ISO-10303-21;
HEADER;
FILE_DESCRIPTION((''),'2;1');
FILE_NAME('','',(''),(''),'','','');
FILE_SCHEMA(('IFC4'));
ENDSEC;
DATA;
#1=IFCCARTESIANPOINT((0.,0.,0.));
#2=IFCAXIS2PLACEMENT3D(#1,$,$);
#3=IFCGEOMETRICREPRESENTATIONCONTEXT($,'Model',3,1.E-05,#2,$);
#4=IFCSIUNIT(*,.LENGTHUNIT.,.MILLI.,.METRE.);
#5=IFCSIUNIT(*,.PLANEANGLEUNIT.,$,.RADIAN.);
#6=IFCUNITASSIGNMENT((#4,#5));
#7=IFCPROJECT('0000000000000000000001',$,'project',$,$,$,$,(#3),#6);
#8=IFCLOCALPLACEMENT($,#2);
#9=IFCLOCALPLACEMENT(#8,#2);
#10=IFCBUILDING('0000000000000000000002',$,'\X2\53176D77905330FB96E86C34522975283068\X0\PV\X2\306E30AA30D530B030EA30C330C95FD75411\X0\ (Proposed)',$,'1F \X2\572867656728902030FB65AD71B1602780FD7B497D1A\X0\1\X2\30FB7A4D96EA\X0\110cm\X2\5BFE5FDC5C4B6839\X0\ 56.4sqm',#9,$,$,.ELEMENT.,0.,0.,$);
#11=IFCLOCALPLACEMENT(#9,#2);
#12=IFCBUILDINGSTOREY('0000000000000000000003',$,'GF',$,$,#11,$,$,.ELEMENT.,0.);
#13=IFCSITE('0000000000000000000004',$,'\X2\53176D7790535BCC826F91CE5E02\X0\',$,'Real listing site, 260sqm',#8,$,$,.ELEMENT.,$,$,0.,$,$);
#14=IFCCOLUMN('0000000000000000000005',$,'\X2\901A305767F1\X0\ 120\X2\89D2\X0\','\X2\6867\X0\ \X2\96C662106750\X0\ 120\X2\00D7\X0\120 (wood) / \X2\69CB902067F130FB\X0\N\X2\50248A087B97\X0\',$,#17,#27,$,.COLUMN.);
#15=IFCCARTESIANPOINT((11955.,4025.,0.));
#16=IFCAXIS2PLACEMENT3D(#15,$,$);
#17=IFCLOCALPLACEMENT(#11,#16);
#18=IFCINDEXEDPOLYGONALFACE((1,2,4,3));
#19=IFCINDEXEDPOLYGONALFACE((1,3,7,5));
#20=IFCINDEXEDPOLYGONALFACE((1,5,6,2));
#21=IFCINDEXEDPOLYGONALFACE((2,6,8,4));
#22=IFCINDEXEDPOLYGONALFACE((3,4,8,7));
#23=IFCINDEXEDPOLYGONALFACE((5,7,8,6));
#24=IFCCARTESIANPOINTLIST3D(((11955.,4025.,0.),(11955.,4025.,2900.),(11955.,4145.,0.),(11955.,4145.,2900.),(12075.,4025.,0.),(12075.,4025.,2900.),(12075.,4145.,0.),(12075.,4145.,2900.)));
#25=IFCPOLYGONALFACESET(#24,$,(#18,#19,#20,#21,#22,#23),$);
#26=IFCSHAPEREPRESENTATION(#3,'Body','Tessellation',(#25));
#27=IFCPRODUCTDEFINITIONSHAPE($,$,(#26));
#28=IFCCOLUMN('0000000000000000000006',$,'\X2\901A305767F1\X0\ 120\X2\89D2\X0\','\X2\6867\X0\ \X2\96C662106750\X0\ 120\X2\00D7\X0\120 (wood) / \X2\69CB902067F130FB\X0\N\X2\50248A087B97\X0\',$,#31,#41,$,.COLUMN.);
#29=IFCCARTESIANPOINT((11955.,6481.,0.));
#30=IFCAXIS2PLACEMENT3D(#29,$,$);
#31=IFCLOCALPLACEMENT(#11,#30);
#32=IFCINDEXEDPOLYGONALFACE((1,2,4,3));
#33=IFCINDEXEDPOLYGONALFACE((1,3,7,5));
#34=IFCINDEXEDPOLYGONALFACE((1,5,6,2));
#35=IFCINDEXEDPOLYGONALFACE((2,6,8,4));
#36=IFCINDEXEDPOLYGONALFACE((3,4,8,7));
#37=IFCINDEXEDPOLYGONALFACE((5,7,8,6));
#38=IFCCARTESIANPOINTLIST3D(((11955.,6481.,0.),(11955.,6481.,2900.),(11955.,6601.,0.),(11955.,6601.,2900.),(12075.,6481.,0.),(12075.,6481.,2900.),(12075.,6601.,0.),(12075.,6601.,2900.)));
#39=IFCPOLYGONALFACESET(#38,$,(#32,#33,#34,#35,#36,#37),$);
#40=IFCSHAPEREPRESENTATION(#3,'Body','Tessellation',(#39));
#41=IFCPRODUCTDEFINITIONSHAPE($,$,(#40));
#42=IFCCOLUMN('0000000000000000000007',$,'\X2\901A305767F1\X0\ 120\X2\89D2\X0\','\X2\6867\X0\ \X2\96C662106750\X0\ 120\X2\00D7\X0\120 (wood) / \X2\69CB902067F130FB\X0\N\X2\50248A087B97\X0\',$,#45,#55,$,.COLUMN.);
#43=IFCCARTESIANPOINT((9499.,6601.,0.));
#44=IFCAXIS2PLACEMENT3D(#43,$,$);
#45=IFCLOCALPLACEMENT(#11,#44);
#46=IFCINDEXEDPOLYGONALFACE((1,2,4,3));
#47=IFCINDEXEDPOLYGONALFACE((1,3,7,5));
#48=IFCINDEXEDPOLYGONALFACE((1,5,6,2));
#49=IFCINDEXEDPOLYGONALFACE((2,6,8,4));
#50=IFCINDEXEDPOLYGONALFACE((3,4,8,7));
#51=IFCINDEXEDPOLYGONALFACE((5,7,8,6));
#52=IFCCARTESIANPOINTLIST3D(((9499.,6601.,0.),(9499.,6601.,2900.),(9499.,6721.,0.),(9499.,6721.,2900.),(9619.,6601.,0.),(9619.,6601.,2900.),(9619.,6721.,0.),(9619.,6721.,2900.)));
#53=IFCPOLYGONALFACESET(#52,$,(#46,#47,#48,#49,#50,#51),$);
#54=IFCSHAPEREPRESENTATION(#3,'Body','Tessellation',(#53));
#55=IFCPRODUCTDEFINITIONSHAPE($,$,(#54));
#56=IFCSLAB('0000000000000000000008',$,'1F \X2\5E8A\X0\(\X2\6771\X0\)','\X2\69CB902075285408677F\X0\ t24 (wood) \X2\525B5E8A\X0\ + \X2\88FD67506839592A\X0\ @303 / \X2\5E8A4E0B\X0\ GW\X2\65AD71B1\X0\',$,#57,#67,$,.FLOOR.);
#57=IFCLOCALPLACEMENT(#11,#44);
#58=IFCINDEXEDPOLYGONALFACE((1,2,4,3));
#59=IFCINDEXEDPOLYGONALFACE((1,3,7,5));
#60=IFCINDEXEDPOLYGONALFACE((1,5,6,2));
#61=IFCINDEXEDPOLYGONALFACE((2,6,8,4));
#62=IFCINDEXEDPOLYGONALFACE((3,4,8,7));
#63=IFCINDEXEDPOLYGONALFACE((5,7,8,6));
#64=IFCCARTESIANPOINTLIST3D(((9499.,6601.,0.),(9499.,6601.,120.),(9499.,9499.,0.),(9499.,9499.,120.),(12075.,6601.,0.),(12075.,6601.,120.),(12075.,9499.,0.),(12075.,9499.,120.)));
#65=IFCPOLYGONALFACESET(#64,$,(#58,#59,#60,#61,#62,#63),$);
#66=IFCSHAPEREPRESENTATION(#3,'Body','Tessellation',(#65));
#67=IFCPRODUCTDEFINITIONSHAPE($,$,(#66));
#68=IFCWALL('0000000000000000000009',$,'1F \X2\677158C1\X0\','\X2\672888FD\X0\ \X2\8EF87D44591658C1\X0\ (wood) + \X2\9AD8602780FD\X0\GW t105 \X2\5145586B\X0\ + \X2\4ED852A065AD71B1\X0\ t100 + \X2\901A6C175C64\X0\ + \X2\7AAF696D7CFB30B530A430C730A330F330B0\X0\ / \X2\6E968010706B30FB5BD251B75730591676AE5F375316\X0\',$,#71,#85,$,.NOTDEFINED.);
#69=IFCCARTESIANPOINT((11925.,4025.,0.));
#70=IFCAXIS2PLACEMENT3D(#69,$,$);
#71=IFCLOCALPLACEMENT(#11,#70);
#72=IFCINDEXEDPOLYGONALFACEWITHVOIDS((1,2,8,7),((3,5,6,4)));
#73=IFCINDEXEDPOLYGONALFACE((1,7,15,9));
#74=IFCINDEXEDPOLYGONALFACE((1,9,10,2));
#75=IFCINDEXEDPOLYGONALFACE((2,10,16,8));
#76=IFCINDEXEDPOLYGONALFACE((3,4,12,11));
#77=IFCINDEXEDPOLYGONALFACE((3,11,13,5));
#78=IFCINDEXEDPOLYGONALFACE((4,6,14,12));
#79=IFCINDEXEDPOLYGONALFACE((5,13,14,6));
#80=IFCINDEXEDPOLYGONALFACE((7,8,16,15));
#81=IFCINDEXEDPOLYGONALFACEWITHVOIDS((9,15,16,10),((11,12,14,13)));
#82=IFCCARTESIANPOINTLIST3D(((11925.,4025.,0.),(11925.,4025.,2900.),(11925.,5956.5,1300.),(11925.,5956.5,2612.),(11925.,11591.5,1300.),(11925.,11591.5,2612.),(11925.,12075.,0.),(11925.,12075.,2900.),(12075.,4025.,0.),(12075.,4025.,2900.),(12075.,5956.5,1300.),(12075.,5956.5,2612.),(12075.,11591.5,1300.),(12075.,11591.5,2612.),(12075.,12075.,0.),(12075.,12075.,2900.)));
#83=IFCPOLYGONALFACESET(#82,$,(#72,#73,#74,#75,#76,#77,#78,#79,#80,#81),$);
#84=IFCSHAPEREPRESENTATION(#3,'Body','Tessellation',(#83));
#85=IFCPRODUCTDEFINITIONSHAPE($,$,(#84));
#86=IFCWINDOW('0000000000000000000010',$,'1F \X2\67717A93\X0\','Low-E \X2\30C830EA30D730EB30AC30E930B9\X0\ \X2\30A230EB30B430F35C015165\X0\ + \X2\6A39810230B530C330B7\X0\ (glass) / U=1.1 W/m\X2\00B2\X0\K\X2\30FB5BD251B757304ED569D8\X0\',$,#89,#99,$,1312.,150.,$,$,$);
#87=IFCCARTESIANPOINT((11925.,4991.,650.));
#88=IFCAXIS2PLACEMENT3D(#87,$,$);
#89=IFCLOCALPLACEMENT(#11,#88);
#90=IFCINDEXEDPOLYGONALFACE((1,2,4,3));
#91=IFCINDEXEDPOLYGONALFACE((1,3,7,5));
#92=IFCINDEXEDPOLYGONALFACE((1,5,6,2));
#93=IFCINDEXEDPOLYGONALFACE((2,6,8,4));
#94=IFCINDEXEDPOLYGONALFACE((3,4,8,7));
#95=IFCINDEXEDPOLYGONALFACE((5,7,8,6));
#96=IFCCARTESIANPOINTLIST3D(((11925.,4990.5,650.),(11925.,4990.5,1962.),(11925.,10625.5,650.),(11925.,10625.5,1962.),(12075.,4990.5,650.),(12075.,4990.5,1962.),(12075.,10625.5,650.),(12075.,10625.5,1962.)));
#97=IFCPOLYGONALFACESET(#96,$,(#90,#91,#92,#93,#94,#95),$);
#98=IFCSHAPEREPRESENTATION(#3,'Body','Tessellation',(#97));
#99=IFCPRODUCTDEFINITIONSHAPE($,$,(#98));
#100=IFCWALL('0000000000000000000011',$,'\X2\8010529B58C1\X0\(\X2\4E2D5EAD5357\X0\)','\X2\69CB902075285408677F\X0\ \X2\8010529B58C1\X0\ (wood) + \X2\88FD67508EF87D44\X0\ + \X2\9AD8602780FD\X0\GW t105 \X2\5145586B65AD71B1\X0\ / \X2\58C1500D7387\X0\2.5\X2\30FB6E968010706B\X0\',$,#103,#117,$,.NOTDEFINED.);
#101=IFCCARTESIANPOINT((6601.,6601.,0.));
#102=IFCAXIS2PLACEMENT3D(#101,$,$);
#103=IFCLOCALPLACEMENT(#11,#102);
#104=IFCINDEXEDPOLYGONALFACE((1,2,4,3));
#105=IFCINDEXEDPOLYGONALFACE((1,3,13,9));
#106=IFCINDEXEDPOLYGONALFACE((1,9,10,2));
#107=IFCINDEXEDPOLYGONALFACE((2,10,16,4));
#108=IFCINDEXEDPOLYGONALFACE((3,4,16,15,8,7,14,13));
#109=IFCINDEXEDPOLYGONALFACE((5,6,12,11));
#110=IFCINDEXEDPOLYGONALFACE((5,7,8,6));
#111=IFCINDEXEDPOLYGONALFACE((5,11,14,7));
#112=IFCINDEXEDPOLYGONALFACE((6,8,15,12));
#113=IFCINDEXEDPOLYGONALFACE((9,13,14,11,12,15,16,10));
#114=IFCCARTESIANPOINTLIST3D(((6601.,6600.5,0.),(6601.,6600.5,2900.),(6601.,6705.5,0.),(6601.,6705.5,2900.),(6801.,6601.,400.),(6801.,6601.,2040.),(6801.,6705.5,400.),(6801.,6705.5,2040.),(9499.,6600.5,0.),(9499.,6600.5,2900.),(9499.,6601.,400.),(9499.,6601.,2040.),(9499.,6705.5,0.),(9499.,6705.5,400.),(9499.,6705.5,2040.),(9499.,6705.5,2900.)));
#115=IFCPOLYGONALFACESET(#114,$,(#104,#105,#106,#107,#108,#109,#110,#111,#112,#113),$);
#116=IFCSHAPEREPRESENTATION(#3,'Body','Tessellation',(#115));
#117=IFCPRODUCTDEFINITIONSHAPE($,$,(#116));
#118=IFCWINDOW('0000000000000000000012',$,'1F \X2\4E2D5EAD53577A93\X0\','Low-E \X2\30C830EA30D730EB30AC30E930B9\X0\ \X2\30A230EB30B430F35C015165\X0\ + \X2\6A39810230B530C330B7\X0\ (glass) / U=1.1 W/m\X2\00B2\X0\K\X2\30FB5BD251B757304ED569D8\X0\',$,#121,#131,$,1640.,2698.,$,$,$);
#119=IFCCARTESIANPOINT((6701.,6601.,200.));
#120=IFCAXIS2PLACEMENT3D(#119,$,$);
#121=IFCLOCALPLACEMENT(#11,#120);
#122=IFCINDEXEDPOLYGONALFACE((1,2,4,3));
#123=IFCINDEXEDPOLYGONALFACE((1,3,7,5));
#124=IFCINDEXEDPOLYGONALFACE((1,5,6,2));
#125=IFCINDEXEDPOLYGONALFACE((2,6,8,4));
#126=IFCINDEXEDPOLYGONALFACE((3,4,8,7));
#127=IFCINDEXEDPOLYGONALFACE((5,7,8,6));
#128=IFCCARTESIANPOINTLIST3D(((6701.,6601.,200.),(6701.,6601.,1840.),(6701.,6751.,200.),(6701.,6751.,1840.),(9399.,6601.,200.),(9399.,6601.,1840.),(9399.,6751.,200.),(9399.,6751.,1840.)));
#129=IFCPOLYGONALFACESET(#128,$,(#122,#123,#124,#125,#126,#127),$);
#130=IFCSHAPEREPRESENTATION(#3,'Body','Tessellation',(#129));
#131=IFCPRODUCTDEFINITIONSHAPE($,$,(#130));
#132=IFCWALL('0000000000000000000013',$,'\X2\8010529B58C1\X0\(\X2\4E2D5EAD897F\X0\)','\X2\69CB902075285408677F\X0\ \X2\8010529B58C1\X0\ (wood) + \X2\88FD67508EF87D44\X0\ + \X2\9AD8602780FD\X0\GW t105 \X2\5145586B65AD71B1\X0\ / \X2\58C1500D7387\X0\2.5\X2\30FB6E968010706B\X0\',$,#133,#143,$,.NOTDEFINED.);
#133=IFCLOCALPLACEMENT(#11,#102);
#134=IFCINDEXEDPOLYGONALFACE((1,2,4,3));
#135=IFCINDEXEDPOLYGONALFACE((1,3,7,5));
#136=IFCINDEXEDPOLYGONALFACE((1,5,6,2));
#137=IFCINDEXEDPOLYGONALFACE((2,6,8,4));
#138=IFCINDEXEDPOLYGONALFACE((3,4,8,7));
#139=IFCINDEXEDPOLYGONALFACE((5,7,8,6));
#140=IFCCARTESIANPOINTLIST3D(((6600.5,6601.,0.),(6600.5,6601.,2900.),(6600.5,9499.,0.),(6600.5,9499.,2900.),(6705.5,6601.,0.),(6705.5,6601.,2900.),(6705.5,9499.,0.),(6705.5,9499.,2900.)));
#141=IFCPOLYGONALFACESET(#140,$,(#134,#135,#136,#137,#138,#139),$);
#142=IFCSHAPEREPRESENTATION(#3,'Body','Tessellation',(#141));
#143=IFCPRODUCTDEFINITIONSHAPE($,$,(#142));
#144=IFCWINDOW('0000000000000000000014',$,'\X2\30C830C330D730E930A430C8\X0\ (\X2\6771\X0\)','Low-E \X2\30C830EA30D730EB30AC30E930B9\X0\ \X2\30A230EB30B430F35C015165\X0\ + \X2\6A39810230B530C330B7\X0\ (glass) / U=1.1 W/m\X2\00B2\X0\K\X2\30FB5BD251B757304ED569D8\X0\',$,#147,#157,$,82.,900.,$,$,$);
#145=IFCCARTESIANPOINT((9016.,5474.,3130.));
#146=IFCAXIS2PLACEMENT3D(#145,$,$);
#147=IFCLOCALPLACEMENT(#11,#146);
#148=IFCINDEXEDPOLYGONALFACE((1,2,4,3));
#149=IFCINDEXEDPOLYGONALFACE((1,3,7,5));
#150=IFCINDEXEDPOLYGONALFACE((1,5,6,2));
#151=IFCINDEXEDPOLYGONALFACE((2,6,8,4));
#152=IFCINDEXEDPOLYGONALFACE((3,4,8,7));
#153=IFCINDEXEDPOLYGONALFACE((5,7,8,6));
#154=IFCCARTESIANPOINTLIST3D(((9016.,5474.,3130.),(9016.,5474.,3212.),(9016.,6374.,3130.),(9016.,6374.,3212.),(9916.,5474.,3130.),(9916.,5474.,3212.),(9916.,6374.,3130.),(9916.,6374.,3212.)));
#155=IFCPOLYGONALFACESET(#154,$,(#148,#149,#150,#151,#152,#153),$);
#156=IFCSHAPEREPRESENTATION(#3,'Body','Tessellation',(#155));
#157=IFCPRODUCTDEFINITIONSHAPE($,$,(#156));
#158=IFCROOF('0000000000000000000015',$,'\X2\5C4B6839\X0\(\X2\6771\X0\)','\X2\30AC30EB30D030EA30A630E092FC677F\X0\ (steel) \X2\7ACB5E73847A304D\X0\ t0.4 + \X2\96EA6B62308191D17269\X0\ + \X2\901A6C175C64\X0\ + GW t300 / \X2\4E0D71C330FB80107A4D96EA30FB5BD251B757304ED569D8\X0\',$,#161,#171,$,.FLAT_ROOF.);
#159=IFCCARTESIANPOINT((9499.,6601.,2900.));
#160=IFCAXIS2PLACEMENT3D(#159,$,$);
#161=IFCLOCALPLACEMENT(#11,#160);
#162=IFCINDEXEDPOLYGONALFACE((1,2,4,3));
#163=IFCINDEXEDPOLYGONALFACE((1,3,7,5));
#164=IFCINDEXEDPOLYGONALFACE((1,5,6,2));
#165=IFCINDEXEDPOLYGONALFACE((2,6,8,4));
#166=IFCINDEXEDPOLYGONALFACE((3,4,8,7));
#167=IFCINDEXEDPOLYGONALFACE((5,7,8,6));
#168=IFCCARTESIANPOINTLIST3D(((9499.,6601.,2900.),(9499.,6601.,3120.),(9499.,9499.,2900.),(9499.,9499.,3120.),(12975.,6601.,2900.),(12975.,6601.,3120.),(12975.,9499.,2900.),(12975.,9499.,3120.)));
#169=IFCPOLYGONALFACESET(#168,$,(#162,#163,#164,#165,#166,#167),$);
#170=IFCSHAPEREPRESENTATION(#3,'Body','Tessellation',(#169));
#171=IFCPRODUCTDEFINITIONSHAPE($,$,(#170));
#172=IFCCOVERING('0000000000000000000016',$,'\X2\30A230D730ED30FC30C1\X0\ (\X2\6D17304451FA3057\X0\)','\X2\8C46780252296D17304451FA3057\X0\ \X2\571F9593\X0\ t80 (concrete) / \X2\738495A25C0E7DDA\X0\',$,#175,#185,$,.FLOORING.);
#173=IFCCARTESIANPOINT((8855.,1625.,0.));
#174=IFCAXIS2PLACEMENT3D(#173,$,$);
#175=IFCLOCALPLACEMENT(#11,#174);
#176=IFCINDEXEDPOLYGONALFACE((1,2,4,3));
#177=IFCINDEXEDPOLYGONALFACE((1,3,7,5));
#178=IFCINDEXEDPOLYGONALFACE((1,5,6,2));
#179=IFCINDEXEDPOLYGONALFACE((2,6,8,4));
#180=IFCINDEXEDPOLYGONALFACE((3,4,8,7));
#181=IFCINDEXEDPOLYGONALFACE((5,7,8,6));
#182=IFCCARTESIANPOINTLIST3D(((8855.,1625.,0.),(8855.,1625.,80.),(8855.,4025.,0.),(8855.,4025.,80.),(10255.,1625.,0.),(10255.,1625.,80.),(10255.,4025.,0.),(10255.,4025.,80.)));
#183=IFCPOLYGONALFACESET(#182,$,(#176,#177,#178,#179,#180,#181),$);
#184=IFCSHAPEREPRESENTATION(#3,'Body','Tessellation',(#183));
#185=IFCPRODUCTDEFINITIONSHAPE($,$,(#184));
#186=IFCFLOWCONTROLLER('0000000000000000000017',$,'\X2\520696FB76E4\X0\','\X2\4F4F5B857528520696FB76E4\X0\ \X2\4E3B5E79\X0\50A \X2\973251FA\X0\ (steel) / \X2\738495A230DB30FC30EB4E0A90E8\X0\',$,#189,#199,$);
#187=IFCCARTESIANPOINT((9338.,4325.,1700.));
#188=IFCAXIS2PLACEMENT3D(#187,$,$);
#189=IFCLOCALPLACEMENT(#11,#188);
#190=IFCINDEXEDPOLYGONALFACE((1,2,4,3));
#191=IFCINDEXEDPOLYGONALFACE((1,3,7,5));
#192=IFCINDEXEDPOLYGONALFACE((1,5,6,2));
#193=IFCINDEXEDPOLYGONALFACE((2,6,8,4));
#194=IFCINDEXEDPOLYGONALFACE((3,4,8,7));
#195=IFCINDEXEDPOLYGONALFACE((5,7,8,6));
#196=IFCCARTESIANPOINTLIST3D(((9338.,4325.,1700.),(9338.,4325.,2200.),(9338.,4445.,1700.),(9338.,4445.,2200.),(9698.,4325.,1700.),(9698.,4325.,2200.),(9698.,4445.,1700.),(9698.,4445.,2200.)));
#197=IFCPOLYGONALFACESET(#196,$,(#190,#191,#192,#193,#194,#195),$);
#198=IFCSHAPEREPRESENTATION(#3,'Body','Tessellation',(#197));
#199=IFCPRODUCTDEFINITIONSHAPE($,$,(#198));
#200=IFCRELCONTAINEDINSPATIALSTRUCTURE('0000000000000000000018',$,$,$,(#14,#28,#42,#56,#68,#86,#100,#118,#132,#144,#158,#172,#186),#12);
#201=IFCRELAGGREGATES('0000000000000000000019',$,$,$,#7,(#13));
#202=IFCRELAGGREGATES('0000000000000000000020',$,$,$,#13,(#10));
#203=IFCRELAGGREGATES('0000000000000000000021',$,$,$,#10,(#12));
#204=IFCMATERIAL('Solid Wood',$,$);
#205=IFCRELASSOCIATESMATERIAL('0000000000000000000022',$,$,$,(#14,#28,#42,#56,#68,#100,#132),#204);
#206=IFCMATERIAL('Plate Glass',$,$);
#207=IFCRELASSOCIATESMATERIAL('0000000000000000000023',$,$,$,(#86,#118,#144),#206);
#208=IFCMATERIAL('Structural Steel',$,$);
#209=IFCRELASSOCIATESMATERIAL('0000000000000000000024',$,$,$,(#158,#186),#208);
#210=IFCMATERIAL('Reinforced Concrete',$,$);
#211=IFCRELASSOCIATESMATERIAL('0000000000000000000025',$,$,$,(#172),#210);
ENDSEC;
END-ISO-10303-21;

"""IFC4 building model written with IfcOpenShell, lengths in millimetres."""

from ifc_helpers import new_model, si_unit, frame, frame_2d, origin, place, context, project, spatial, rectangle, extrude, material, element, fill, save


model = new_model("IFC4")

# Units and contexts
model_context = context("Model", 3, precision=1e-05, world=origin())
ifc_project = project(units=[si_unit("LENGTHUNIT", "METRE", prefix="MILLI"), si_unit("PLANEANGLEUNIT", "RADIAN")], contexts=[model_context])

# Site, building, storey
site_placement = place(None, origin())
site = spatial("IfcSite", under=ifc_project, at=site_placement, Name="北海道富良野市", ObjectType="Real listing site, 260sqm", CompositionType="ELEMENT", RefElevation=0.0)
building_placement = place(site_placement, origin())
building = spatial("IfcBuilding", under=site, at=building_placement, Name="北海道・雨水利用とPVのオフグリッド志向 (Proposed)", ObjectType="1F 在来木造・断熱性能等級1・積雪110cm対応屋根 56.4sqm", CompositionType="ELEMENT", ElevationOfRefHeight=0.0, ElevationOfTerrain=0.0)
storey_placement = place(building_placement, origin())
storey = spatial("IfcBuildingStorey", under=building, at=storey_placement, Name="GF", CompositionType="ELEMENT", Elevation=0.0)

# Columns
ifc_material_1 = material(Name="Solid Wood")
column_1_placement = place(storey_placement, frame((11955.0, 4025.0, 0.0)))
element("IfcColumn", 1, at=column_1_placement, inside=storey, material=ifc_material_1, Name="通し柱 120角", Description="桧 集成材 120×120 (wood) / 構造柱・N値計算", PredefinedType="COLUMN", context=model_context, shape_type="SweptSolid", body=[
    extrude(rectangle(XDim=120.0, YDim=120.0, at=frame_2d((60.0, 60.0))), frame((11955.0, 4025.0, 0.0)), (0.0, 0.0, 1.0), 2900.0),
])
column_2_placement = place(storey_placement, frame((11955.0, 6481.0, 0.0)))
element("IfcColumn", 2, at=column_2_placement, inside=storey, material=ifc_material_1, Name="通し柱 120角", Description="桧 集成材 120×120 (wood) / 構造柱・N値計算", PredefinedType="COLUMN", context=model_context, shape_type="SweptSolid", body=[
    extrude(rectangle(XDim=120.0, YDim=120.0, at=frame_2d((60.0, 60.0))), frame((11955.0, 6481.0, 0.0)), (0.0, 0.0, 1.0), 2900.0),
])
column_3_placement = place(storey_placement, frame((9499.0, 6601.0, 0.0)))
element("IfcColumn", 3, at=column_3_placement, inside=storey, material=ifc_material_1, Name="通し柱 120角", Description="桧 集成材 120×120 (wood) / 構造柱・N値計算", PredefinedType="COLUMN", context=model_context, shape_type="SweptSolid", body=[
    extrude(rectangle(XDim=120.0, YDim=120.0, at=frame_2d((60.0, 60.0))), frame((9499.0, 6601.0, 0.0)), (0.0, 0.0, 1.0), 2900.0),
])

# Slab
slab_placement = place(storey_placement, frame((9499.0, 6601.0, 0.0)))
element("IfcSlab", 4, at=slab_placement, inside=storey, material=ifc_material_1, Name="1F 床(東)", Description="構造用合板 t24 (wood) 剛床 + 製材根太 @303 / 床下 GW断熱", PredefinedType="FLOOR", context=model_context, shape_type="SweptSolid", body=[
    extrude(rectangle(XDim=2576.0, YDim=2898.0, at=frame_2d((1288.0, 1449.0))), frame((9499.0, 6601.0, 0.0)), (0.0, 0.0, 1.0), 120.0),
])

# Walls, openings, windows
wall_1_placement = place(storey_placement, frame((11925.0, 4025.0, 0.0)))
wall_1 = element("IfcWall", 5, at=wall_1_placement, inside=storey, material=ifc_material_1, Name="1F 東壁", Description="木製 軸組外壁 (wood) + 高性能GW t105 充填 + 付加断熱 t100 + 通気層 + 窯業系サイディング / 準耐火・寒冷地外皮強化", PredefinedType="NOTDEFINED", context=model_context, shape_type="SweptSolid", body=[
    extrude(rectangle(XDim=150.0, YDim=8050.0, at=frame_2d((75.0, 4025.0))), frame((11925.0, 4025.0, 0.0)), (0.0, 0.0, 1.0), 2900.0),
])
opening_1_placement = place(storey_placement, frame((11925.0, 4991.0, 650.0)))
opening_1 = element("IfcOpeningElement", 6, at=opening_1_placement, cuts=wall_1, PredefinedType="NOTDEFINED", context=model_context, shape_type="SweptSolid", body=[
    extrude(rectangle(XDim=150.0, YDim=5635.0, at=frame_2d((75.0, 2817.0))), frame((11925.0, 4991.0, 650.0)), (0.0, 0.0, 1.0), 1312.0),
])
ifc_material_2 = material(Name="Plate Glass")
window_1_placement = place(storey_placement, frame((11925.0, 4991.0, 650.0)))
window_1 = element("IfcWindow", 7, at=window_1_placement, inside=storey, material=ifc_material_2, Name="1F 東窓", Description="Low-E トリプルガラス アルゴン封入 + 樹脂サッシ (glass) / U=1.1 W/m²K・寒冷地仕様", OverallHeight=1312.0, OverallWidth=150.0, context=model_context, shape_type="SweptSolid", body=[
    extrude(rectangle(XDim=150.0, YDim=5635.0, at=frame_2d((75.0, 2817.0))), frame((11925.0, 4991.0, 650.0)), (0.0, 0.0, 1.0), 1312.0),
])
fill(opening_1, window_1)
wall_2_placement = place(storey_placement, frame((6601.0, 6601.0, 0.0)))
wall_2 = element("IfcWall", 8, at=wall_2_placement, inside=storey, material=ifc_material_1, Name="耐力壁(中庭南)", Description="構造用合板 耐力壁 (wood) + 製材軸組 + 高性能GW t105 充填断熱 / 壁倍率2.5・準耐火", PredefinedType="NOTDEFINED", context=model_context, shape_type="SweptSolid", body=[
    extrude(rectangle(XDim=2898.0, YDim=105.0, at=frame_2d((1449.0, 52.0))), frame((6601.0, 6601.0, 0.0)), (0.0, 0.0, 1.0), 2900.0),
])
opening_2_placement = place(storey_placement, frame((6701.0, 6601.0, 200.0)))
opening_2 = element("IfcOpeningElement", 9, at=opening_2_placement, cuts=wall_2, PredefinedType="NOTDEFINED", context=model_context, shape_type="SweptSolid", body=[
    extrude(rectangle(XDim=2698.0, YDim=150.0, at=frame_2d((1349.0, 75.0))), frame((6701.0, 6601.0, 200.0)), (0.0, 0.0, 1.0), 1640.0),
])
window_2_placement = place(storey_placement, frame((6701.0, 6601.0, 200.0)))
window_2 = element("IfcWindow", 10, at=window_2_placement, inside=storey, material=ifc_material_2, Name="1F 中庭南窓", Description="Low-E トリプルガラス アルゴン封入 + 樹脂サッシ (glass) / U=1.1 W/m²K・寒冷地仕様", OverallHeight=1640.0, OverallWidth=2698.0, context=model_context, shape_type="SweptSolid", body=[
    extrude(rectangle(XDim=2698.0, YDim=150.0, at=frame_2d((1349.0, 75.0))), frame((6701.0, 6601.0, 200.0)), (0.0, 0.0, 1.0), 1640.0),
])
fill(opening_2, window_2)

# Wall
wall_3_placement = place(storey_placement, frame((6601.0, 6601.0, 0.0)))
element("IfcWall", 11, at=wall_3_placement, inside=storey, material=ifc_material_1, Name="耐力壁(中庭西)", Description="構造用合板 耐力壁 (wood) + 製材軸組 + 高性能GW t105 充填断熱 / 壁倍率2.5・準耐火", PredefinedType="NOTDEFINED", context=model_context, shape_type="SweptSolid", body=[
    extrude(rectangle(XDim=105.0, YDim=2898.0, at=frame_2d((52.0, 1449.0))), frame((6601.0, 6601.0, 0.0)), (0.0, 0.0, 1.0), 2900.0),
])

# Window
window_3_placement = place(storey_placement, frame((9016.0, 5474.0, 3130.0)))
element("IfcWindow", 12, at=window_3_placement, inside=storey, material=ifc_material_2, Name="トップライト (東)", Description="Low-E トリプルガラス アルゴン封入 + 樹脂サッシ (glass) / U=1.1 W/m²K・寒冷地仕様", OverallHeight=82.0, OverallWidth=900.0, context=model_context, shape_type="SweptSolid", body=[
    extrude(rectangle(XDim=900.0, YDim=900.0, at=frame_2d((450.0, 450.0))), frame((9016.0, 5474.0, 3130.0)), (0.0, 0.0, 1.0), 82.0),
])

# Roof
ifc_material_3 = material(Name="Structural Steel")
roof_placement = place(storey_placement, frame((9499.0, 6601.0, 2900.0)))
element("IfcRoof", 13, at=roof_placement, inside=storey, material=ifc_material_3, Name="屋根(東)", Description="ガルバリウム鋼板 (steel) 立平葺き t0.4 + 雪止め金物 + 通気層 + GW t300 / 不燃・耐積雪・寒冷地仕様", PredefinedType="FLAT_ROOF", context=model_context, shape_type="SweptSolid", body=[
    extrude(rectangle(XDim=3476.0, YDim=2898.0, at=frame_2d((1738.0, 1449.0))), frame((9499.0, 6601.0, 2900.0)), (0.0, 0.0, 1.0), 220.0),
])

# Covering
ifc_material_4 = material(Name="Reinforced Concrete")
covering_placement = place(storey_placement, frame((8855.0, 1625.0, 0.0)))
element("IfcCovering", 14, at=covering_placement, inside=storey, material=ifc_material_4, Name="アプローチ (洗い出し)", Description="豆砂利洗い出し 土間 t80 (concrete) / 玄関導線", PredefinedType="FLOORING", context=model_context, shape_type="SweptSolid", body=[
    extrude(rectangle(XDim=1400.0, YDim=2400.0, at=frame_2d((700.0, 1200.0))), frame((8855.0, 1625.0, 0.0)), (0.0, 0.0, 1.0), 80.0),
])

# Flow controller
flow_controller_placement = place(storey_placement, frame((9338.0, 4325.0, 1700.0)))
element("IfcFlowController", 15, at=flow_controller_placement, inside=storey, material=ifc_material_3, Name="分電盤", Description="住宅用分電盤 主幹50A 露出 (steel) / 玄関ホール上部", context=model_context, shape_type="SweptSolid", body=[
    extrude(rectangle(XDim=360.0, YDim=120.0, at=frame_2d((180.0, 60.0))), frame((9338.0, 4325.0, 1700.0)), (0.0, 0.0, 1.0), 500.0),
])

save(model, "model.ifc")
